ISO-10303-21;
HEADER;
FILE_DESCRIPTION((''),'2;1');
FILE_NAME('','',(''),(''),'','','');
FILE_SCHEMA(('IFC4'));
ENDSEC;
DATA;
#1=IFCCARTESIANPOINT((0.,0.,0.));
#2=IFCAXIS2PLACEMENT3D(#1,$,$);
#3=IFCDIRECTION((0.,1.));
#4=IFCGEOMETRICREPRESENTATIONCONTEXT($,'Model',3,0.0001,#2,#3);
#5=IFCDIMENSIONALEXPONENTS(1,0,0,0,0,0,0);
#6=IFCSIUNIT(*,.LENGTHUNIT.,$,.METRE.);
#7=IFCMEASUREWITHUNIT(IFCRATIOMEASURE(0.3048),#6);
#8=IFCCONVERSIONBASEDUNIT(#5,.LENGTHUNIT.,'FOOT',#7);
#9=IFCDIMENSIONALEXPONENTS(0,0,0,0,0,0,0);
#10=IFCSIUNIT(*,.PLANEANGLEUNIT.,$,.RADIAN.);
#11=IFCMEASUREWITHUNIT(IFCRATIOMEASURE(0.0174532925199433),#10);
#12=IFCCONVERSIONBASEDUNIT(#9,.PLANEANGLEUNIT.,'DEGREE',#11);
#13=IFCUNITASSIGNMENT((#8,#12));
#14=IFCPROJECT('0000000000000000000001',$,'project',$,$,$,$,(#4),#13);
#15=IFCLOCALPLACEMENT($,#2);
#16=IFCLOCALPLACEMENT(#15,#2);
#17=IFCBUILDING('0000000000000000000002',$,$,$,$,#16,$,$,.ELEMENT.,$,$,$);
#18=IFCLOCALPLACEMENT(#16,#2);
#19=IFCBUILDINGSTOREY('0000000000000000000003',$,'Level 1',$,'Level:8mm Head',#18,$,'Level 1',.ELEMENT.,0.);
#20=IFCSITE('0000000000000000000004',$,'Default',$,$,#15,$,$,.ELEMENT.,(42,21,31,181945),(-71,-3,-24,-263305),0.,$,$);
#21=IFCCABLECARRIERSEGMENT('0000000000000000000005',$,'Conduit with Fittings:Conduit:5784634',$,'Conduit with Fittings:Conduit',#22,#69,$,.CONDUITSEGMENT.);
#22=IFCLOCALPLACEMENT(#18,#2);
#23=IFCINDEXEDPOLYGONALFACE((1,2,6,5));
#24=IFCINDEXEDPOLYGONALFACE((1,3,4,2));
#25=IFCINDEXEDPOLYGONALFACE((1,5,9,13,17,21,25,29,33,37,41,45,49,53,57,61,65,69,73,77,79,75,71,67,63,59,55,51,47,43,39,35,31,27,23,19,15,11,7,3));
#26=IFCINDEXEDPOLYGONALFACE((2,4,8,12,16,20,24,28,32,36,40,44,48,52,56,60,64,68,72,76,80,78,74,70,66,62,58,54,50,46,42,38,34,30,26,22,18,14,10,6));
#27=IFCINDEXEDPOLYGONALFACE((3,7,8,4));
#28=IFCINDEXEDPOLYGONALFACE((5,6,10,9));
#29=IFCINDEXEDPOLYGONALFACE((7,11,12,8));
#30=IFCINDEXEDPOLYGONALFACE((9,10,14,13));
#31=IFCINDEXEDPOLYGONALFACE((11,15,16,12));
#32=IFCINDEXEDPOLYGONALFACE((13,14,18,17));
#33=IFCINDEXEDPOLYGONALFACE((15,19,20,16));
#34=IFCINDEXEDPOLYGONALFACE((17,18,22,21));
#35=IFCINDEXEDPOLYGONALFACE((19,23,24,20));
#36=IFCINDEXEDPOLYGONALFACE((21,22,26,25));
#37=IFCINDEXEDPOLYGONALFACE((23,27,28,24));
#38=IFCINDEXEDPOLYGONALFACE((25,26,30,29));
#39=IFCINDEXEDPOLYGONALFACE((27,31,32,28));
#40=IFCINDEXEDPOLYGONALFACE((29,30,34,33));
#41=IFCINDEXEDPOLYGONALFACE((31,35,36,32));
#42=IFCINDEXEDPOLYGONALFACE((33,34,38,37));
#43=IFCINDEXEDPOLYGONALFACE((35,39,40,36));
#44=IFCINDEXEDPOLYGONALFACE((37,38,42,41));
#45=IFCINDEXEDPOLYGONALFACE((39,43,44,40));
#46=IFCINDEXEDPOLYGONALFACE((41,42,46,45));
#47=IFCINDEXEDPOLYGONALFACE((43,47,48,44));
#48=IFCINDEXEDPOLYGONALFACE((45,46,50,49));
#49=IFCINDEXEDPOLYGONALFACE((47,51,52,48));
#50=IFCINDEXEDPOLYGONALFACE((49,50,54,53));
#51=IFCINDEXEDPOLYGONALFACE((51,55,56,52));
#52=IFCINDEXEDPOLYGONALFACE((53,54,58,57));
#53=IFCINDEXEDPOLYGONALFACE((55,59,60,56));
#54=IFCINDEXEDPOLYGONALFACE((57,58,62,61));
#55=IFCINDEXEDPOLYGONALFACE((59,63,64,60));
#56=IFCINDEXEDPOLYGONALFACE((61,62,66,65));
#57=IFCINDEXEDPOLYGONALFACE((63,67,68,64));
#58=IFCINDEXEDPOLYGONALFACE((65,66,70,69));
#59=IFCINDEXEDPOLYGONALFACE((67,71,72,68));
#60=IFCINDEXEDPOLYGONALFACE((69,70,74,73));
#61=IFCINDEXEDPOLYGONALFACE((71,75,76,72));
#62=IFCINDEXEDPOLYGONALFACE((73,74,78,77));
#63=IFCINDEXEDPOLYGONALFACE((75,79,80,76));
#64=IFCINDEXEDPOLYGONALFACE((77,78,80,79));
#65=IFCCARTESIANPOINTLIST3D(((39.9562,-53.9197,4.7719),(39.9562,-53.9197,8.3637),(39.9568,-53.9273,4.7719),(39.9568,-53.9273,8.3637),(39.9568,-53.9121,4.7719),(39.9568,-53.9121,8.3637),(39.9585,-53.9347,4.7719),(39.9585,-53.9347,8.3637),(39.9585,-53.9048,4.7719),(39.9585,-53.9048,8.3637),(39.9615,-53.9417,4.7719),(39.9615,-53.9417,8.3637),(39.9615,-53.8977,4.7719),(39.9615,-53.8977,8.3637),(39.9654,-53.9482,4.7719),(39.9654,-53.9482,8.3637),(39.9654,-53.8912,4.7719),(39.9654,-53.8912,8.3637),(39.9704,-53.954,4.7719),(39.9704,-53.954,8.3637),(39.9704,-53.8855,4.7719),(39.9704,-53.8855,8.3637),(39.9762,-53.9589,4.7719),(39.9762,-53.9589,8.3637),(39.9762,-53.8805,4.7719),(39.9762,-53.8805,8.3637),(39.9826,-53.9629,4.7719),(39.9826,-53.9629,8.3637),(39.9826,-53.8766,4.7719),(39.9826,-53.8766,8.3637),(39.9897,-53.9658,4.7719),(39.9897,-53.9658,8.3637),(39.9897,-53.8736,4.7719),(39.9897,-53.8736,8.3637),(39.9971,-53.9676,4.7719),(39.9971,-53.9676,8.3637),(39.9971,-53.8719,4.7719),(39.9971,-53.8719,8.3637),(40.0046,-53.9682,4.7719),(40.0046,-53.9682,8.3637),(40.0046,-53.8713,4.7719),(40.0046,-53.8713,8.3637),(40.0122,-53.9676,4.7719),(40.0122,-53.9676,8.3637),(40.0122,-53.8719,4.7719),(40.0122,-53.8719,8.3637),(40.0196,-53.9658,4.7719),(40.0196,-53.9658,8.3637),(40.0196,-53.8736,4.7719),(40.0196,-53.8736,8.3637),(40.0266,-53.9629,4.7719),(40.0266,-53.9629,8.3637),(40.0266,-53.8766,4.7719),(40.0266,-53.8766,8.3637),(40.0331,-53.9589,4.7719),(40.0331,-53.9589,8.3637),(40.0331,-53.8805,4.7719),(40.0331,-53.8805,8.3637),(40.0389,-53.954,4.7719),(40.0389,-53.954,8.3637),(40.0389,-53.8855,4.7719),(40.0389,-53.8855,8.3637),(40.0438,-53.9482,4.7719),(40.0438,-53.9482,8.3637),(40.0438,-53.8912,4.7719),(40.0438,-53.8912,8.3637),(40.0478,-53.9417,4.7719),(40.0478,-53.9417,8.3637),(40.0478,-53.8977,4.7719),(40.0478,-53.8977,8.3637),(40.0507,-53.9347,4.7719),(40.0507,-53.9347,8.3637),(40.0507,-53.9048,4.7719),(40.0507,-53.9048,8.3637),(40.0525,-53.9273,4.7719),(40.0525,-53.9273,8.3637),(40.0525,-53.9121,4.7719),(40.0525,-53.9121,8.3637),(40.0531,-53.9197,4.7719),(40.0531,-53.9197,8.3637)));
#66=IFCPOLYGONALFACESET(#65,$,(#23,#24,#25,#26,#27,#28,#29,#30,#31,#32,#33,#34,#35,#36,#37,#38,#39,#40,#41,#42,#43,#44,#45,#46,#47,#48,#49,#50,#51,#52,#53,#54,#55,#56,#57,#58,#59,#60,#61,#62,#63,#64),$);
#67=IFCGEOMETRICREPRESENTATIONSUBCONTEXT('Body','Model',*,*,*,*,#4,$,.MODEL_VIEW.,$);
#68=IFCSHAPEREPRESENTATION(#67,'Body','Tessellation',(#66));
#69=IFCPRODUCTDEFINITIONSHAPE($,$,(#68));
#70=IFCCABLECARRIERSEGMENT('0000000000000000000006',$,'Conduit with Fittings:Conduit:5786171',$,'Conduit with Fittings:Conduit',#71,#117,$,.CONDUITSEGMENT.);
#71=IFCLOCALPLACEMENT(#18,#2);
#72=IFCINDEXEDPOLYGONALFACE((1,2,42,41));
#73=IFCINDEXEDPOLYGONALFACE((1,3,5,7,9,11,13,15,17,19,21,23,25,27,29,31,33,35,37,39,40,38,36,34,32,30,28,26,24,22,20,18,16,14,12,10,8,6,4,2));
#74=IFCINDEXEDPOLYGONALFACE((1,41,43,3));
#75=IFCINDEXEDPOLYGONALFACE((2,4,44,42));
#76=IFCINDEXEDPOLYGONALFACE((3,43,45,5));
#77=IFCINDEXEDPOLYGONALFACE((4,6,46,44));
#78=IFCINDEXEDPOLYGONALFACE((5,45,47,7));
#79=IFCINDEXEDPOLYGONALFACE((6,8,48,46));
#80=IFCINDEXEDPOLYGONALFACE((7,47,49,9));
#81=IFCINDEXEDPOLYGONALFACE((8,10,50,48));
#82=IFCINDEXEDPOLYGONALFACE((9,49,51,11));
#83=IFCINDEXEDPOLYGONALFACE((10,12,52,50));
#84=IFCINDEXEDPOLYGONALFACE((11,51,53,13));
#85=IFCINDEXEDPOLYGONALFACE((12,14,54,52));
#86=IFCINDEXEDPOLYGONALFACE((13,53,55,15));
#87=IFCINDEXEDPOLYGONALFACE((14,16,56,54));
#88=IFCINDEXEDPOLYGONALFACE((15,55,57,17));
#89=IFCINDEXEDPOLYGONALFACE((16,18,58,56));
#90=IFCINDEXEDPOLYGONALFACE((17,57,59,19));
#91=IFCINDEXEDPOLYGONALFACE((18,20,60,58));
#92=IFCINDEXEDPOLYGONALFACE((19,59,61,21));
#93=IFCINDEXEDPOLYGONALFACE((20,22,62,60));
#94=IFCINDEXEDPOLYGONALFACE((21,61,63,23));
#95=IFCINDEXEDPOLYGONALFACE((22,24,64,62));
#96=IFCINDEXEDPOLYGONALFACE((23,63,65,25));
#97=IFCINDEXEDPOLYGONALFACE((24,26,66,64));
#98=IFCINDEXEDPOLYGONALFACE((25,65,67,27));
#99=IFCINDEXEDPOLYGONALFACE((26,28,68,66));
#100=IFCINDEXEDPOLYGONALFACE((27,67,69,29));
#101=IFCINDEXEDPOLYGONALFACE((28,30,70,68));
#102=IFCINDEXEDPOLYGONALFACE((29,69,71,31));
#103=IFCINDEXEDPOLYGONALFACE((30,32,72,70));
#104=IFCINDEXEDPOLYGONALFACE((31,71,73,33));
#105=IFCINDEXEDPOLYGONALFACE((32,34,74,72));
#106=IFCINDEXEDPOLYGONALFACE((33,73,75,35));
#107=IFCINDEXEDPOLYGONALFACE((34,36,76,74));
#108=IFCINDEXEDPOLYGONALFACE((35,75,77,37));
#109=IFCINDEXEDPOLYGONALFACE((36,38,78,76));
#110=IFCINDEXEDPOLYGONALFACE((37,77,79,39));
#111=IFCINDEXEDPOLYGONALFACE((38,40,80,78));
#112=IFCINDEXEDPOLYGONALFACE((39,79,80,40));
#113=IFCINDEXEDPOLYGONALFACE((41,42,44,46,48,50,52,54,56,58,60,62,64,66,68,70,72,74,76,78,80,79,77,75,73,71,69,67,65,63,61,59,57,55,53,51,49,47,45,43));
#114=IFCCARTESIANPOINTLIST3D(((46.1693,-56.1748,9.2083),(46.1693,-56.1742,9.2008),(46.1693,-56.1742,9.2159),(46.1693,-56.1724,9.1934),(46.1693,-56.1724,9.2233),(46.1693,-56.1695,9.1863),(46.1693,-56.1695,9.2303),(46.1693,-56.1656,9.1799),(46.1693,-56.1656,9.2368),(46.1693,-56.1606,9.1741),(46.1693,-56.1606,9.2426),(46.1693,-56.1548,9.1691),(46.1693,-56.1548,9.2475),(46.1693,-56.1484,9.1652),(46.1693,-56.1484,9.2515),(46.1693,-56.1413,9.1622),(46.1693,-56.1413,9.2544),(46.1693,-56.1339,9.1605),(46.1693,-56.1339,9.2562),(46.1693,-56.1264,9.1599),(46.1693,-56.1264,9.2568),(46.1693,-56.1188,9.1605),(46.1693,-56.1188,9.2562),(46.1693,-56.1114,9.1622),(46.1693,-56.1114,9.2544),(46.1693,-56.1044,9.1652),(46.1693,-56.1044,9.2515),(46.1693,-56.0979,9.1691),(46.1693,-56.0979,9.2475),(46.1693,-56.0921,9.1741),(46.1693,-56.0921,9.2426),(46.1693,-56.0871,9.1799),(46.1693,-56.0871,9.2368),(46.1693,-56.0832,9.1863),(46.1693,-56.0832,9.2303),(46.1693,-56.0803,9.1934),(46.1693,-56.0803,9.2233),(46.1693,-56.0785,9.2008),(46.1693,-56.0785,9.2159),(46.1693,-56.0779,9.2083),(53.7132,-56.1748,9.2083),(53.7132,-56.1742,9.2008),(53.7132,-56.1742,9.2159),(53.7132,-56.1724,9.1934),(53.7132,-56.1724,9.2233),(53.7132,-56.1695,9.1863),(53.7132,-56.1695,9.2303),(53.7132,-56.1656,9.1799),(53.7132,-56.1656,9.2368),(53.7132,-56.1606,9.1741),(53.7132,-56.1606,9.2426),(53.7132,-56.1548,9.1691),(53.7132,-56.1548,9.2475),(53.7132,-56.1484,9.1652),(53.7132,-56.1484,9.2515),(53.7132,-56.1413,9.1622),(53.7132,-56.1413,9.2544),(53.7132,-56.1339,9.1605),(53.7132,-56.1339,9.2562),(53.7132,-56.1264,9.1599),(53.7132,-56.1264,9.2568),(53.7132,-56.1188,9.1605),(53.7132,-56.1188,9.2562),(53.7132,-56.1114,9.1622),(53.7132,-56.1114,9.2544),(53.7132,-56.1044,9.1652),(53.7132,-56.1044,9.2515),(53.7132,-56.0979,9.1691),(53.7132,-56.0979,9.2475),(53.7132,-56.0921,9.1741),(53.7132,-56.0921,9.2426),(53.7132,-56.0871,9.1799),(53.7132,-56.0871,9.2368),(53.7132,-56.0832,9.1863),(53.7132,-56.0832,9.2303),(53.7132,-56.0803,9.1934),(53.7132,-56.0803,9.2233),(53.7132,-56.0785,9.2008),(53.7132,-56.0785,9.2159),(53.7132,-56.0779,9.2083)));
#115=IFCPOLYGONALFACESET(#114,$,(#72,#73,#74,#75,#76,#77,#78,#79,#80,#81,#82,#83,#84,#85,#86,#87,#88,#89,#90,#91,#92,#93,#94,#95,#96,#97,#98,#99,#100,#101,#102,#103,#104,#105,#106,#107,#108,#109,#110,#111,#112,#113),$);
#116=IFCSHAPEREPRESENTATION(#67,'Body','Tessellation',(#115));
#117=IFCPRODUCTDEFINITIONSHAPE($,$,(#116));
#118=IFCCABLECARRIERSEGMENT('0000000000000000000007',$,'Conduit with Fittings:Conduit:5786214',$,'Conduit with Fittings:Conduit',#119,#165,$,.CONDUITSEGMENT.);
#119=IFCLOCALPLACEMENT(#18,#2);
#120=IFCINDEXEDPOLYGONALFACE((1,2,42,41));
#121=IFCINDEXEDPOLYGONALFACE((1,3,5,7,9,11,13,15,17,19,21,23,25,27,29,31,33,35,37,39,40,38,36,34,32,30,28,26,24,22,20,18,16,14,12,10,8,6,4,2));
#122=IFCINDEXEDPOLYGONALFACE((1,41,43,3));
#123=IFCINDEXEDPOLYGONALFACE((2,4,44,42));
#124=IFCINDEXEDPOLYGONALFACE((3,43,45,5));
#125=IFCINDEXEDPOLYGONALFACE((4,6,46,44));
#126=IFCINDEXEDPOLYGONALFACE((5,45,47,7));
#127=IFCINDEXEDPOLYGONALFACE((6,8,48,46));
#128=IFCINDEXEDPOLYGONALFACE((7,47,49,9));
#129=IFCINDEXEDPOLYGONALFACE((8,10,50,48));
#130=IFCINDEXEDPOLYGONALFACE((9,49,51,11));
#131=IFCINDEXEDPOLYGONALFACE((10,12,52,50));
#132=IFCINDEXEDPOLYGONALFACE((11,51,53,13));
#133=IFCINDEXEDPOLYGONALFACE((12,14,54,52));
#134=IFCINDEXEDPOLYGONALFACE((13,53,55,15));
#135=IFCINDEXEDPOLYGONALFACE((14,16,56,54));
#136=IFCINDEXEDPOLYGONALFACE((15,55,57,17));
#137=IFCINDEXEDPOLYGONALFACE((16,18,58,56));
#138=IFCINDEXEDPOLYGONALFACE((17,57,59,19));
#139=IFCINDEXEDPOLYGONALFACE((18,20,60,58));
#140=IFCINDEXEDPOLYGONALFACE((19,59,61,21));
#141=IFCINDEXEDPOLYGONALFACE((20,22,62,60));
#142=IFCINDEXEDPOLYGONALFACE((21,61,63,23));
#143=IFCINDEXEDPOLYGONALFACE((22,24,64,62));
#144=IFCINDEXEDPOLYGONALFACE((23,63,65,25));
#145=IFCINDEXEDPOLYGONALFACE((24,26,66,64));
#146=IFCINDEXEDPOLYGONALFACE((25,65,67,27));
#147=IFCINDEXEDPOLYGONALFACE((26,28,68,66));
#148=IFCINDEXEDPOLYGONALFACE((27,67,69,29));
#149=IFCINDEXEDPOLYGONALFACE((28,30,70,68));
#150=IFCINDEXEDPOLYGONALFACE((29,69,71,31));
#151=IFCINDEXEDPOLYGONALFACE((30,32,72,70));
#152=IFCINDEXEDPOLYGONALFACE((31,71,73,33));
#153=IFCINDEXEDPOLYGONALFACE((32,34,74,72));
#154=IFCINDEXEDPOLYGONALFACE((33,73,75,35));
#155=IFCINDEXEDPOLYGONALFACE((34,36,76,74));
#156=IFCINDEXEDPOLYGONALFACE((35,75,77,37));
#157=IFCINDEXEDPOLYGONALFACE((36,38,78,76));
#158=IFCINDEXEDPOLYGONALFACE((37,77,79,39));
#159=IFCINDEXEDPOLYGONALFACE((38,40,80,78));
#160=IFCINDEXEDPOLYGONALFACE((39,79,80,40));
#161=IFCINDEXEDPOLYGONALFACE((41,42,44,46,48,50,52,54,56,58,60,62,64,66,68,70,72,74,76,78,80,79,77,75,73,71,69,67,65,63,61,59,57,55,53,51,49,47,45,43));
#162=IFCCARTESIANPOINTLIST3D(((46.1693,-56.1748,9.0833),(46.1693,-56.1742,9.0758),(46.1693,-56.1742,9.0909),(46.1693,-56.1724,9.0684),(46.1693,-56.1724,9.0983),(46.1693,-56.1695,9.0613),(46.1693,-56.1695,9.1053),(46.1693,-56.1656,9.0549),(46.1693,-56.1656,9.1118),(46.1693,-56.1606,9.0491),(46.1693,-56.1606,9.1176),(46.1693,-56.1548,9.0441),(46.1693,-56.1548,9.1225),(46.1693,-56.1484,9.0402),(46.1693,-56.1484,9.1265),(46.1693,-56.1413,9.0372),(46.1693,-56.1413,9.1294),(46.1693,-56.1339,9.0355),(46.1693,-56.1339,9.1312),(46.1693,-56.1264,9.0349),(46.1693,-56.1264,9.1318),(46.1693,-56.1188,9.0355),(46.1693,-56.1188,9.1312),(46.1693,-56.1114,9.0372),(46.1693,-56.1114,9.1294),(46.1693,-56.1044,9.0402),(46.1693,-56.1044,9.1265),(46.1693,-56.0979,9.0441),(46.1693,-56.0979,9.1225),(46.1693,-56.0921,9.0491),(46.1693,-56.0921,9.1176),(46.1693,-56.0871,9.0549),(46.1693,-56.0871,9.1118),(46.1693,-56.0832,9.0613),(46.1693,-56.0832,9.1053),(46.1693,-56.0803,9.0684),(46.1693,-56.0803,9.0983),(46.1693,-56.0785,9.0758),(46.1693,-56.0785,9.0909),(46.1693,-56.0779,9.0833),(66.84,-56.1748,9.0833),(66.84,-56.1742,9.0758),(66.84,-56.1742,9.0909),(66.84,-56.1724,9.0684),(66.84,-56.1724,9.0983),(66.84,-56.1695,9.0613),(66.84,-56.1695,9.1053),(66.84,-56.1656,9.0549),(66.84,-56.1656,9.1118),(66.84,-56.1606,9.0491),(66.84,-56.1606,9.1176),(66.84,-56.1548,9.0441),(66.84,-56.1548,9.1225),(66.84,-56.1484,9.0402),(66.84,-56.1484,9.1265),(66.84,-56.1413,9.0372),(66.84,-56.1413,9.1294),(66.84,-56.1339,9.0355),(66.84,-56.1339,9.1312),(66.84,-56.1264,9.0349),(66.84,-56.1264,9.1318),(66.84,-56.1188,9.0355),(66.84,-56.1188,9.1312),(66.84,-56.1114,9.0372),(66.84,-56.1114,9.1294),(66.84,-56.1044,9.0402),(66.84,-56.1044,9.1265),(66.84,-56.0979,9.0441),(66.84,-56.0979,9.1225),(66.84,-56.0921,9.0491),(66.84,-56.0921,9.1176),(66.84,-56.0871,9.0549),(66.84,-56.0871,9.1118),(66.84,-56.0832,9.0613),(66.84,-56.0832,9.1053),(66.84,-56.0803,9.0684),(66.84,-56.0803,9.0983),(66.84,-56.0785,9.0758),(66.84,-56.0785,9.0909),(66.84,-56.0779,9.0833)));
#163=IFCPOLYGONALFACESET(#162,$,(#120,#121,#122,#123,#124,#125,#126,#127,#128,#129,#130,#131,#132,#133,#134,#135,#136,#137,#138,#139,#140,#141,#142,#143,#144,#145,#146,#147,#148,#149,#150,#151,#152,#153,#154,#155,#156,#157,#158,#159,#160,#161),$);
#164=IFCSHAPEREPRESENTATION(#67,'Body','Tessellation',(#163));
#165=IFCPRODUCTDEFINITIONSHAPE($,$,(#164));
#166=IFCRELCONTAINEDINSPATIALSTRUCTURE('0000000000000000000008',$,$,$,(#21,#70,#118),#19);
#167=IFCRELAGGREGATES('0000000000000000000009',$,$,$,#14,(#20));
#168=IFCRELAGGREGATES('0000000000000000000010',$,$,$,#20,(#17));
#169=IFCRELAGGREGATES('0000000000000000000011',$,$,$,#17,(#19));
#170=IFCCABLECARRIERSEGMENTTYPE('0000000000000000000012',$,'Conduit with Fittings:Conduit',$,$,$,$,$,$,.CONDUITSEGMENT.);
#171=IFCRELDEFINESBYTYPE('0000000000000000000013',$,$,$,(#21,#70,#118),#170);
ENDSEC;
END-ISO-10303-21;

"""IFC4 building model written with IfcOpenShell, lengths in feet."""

from ifc_helpers import new_model, entity, si_unit, converted_unit, direction, frame, origin, place, context, subcontext, project, spatial, indexed_curve, outline, extrude, type_object, element, save


model = new_model("IFC4")

# Units and contexts
model_context = context("Model", 3, precision=0.0001, world=origin(), true_north=direction((0.0, 1.0)))
body_context = subcontext(model_context, "Body", "Model", "MODEL_VIEW")
ifc_project = project(units=[converted_unit("LENGTHUNIT", "FOOT", entity("IfcRatioMeasure", 0.3048), si_unit("LENGTHUNIT", "METRE"), dimensions=[1, 0, 0, 0, 0, 0, 0]), converted_unit("PLANEANGLEUNIT", "DEGREE", entity("IfcRatioMeasure", 0.0174532925199433), si_unit("PLANEANGLEUNIT", "RADIAN"), dimensions=[0, 0, 0, 0, 0, 0, 0])], contexts=[model_context])

# Site, building, storey
site_placement = place(None, origin())
site = spatial("IfcSite", under=ifc_project, at=site_placement, Name="Default", CompositionType="ELEMENT", RefLatitude=(42, 21, 31, 181945), RefLongitude=(-71, -3, -24, -263305), RefElevation=0.0)
building_placement = place(site_placement, origin())
building = spatial("IfcBuilding", under=site, at=building_placement, CompositionType="ELEMENT")
storey_placement = place(building_placement, origin())
storey = spatial("IfcBuildingStorey", under=building, at=storey_placement, Name="Level 1", ObjectType="Level:8mm Head", LongName="Level 1", CompositionType="ELEMENT", Elevation=0.0)

# Cable carrier segments
cable_carrier_segment_type_1 = type_object("IfcCableCarrierSegmentType", Name="Conduit with Fittings:Conduit", PredefinedType="CONDUITSEGMENT")
cable_carrier_segment_1_placement = place(storey_placement, origin())
element("IfcCableCarrierSegment", 1, at=cable_carrier_segment_1_placement, inside=storey, type_object=cable_carrier_segment_type_1, Name="Conduit with Fittings:Conduit:5784634", ObjectType="Conduit with Fittings:Conduit", PredefinedType="CONDUITSEGMENT", context=body_context, shape_type="SweptSolid", body=[
    extrude(outline(indexed_curve([(0.0485, 0.0), (0.0479, 0.0076), (0.0461, 0.015), (0.0432, 0.022), (0.0392, 0.0285), (0.0343, 0.0343), (0.0285, 0.0392), (0.022, 0.0432), (0.015, 0.0461), (0.0076, 0.0479), (0.0, 0.0485), (-0.0076, 0.0479), (-0.015, 0.0461), (-0.022, 0.0432), (-0.0285, 0.0392), (-0.0343, 0.0343), (-0.0392, 0.0285), (-0.0432, 0.022), (-0.0461, 0.015), (-0.0479, 0.0076), (-0.0485, 0.0), (-0.0479, -0.0076), (-0.0461, -0.015), (-0.0432, -0.022), (-0.0392, -0.0285), (-0.0343, -0.0343), (-0.0285, -0.0392), (-0.022, -0.0432), (-0.015, -0.0461), (-0.0076, -0.0479), (0.0, -0.0485), (0.0076, -0.0479), (0.015, -0.0461), (0.022, -0.0432), (0.0285, -0.0392), (0.0343, -0.0343), (0.0392, -0.0285), (0.0432, -0.022), (0.0461, -0.015), (0.0479, -0.0076), (0.0485, 0.0)], self_intersect=False)), frame((40.0046, -53.9197, 4.7719)), (0.0, 0.0, 1.0), 3.5917),
])
cable_carrier_segment_2_placement = place(storey_placement, origin())
element("IfcCableCarrierSegment", 2, at=cable_carrier_segment_2_placement, inside=storey, type_object=cable_carrier_segment_type_1, Name="Conduit with Fittings:Conduit:5786171", ObjectType="Conduit with Fittings:Conduit", PredefinedType="CONDUITSEGMENT", context=body_context, shape_type="SweptSolid", body=[
    extrude(outline(indexed_curve([(0.0485, 0.0), (0.0479, 0.0076), (0.0461, 0.015), (0.0432, 0.022), (0.0392, 0.0285), (0.0343, 0.0343), (0.0285, 0.0392), (0.022, 0.0432), (0.015, 0.0461), (0.0076, 0.0479), (0.0, 0.0485), (-0.0076, 0.0479), (-0.015, 0.0461), (-0.022, 0.0432), (-0.0285, 0.0392), (-0.0343, 0.0343), (-0.0392, 0.0285), (-0.0432, 0.022), (-0.0461, 0.015), (-0.0479, 0.0076), (-0.0485, 0.0), (-0.0479, -0.0076), (-0.0461, -0.015), (-0.0432, -0.022), (-0.0392, -0.0285), (-0.0343, -0.0343), (-0.0285, -0.0392), (-0.022, -0.0432), (-0.015, -0.0461), (-0.0076, -0.0479), (0.0, -0.0485), (0.0076, -0.0479), (0.015, -0.0461), (0.022, -0.0432), (0.0285, -0.0392), (0.0343, -0.0343), (0.0392, -0.0285), (0.0432, -0.022), (0.0461, -0.015), (0.0479, -0.0076), (0.0485, 0.0)], self_intersect=False)), frame((46.1693, -56.1264, 9.2083), z_axis=(1.0, 0.0, 0.0), x_axis=(0.0, 1.0, 0.0)), (0.0, 0.0, 1.0), 7.5439),
])
cable_carrier_segment_3_placement = place(storey_placement, origin())
element("IfcCableCarrierSegment", 3, at=cable_carrier_segment_3_placement, inside=storey, type_object=cable_carrier_segment_type_1, Name="Conduit with Fittings:Conduit:5786214", ObjectType="Conduit with Fittings:Conduit", PredefinedType="CONDUITSEGMENT", context=body_context, shape_type="SweptSolid", body=[
    extrude(outline(indexed_curve([(0.0485, 0.0), (0.0479, 0.0076), (0.0461, 0.015), (0.0432, 0.022), (0.0392, 0.0285), (0.0343, 0.0343), (0.0285, 0.0392), (0.022, 0.0432), (0.015, 0.0461), (0.0076, 0.0479), (0.0, 0.0485), (-0.0076, 0.0479), (-0.015, 0.0461), (-0.022, 0.0432), (-0.0285, 0.0392), (-0.0343, 0.0343), (-0.0392, 0.0285), (-0.0432, 0.022), (-0.0461, 0.015), (-0.0479, 0.0076), (-0.0485, 0.0), (-0.0479, -0.0076), (-0.0461, -0.015), (-0.0432, -0.022), (-0.0392, -0.0285), (-0.0343, -0.0343), (-0.0285, -0.0392), (-0.022, -0.0432), (-0.015, -0.0461), (-0.0076, -0.0479), (0.0, -0.0485), (0.0076, -0.0479), (0.015, -0.0461), (0.022, -0.0432), (0.0285, -0.0392), (0.0343, -0.0343), (0.0392, -0.0285), (0.0432, -0.022), (0.0461, -0.015), (0.0479, -0.0076), (0.0485, 0.0)], self_intersect=False)), frame((46.1693, -56.1264, 9.0833), z_axis=(1.0, 0.0, 0.0), x_axis=(0.0, 1.0, 0.0)), (0.0, 0.0, 1.0), 20.6707),
])

save(model, "model.ifc")
